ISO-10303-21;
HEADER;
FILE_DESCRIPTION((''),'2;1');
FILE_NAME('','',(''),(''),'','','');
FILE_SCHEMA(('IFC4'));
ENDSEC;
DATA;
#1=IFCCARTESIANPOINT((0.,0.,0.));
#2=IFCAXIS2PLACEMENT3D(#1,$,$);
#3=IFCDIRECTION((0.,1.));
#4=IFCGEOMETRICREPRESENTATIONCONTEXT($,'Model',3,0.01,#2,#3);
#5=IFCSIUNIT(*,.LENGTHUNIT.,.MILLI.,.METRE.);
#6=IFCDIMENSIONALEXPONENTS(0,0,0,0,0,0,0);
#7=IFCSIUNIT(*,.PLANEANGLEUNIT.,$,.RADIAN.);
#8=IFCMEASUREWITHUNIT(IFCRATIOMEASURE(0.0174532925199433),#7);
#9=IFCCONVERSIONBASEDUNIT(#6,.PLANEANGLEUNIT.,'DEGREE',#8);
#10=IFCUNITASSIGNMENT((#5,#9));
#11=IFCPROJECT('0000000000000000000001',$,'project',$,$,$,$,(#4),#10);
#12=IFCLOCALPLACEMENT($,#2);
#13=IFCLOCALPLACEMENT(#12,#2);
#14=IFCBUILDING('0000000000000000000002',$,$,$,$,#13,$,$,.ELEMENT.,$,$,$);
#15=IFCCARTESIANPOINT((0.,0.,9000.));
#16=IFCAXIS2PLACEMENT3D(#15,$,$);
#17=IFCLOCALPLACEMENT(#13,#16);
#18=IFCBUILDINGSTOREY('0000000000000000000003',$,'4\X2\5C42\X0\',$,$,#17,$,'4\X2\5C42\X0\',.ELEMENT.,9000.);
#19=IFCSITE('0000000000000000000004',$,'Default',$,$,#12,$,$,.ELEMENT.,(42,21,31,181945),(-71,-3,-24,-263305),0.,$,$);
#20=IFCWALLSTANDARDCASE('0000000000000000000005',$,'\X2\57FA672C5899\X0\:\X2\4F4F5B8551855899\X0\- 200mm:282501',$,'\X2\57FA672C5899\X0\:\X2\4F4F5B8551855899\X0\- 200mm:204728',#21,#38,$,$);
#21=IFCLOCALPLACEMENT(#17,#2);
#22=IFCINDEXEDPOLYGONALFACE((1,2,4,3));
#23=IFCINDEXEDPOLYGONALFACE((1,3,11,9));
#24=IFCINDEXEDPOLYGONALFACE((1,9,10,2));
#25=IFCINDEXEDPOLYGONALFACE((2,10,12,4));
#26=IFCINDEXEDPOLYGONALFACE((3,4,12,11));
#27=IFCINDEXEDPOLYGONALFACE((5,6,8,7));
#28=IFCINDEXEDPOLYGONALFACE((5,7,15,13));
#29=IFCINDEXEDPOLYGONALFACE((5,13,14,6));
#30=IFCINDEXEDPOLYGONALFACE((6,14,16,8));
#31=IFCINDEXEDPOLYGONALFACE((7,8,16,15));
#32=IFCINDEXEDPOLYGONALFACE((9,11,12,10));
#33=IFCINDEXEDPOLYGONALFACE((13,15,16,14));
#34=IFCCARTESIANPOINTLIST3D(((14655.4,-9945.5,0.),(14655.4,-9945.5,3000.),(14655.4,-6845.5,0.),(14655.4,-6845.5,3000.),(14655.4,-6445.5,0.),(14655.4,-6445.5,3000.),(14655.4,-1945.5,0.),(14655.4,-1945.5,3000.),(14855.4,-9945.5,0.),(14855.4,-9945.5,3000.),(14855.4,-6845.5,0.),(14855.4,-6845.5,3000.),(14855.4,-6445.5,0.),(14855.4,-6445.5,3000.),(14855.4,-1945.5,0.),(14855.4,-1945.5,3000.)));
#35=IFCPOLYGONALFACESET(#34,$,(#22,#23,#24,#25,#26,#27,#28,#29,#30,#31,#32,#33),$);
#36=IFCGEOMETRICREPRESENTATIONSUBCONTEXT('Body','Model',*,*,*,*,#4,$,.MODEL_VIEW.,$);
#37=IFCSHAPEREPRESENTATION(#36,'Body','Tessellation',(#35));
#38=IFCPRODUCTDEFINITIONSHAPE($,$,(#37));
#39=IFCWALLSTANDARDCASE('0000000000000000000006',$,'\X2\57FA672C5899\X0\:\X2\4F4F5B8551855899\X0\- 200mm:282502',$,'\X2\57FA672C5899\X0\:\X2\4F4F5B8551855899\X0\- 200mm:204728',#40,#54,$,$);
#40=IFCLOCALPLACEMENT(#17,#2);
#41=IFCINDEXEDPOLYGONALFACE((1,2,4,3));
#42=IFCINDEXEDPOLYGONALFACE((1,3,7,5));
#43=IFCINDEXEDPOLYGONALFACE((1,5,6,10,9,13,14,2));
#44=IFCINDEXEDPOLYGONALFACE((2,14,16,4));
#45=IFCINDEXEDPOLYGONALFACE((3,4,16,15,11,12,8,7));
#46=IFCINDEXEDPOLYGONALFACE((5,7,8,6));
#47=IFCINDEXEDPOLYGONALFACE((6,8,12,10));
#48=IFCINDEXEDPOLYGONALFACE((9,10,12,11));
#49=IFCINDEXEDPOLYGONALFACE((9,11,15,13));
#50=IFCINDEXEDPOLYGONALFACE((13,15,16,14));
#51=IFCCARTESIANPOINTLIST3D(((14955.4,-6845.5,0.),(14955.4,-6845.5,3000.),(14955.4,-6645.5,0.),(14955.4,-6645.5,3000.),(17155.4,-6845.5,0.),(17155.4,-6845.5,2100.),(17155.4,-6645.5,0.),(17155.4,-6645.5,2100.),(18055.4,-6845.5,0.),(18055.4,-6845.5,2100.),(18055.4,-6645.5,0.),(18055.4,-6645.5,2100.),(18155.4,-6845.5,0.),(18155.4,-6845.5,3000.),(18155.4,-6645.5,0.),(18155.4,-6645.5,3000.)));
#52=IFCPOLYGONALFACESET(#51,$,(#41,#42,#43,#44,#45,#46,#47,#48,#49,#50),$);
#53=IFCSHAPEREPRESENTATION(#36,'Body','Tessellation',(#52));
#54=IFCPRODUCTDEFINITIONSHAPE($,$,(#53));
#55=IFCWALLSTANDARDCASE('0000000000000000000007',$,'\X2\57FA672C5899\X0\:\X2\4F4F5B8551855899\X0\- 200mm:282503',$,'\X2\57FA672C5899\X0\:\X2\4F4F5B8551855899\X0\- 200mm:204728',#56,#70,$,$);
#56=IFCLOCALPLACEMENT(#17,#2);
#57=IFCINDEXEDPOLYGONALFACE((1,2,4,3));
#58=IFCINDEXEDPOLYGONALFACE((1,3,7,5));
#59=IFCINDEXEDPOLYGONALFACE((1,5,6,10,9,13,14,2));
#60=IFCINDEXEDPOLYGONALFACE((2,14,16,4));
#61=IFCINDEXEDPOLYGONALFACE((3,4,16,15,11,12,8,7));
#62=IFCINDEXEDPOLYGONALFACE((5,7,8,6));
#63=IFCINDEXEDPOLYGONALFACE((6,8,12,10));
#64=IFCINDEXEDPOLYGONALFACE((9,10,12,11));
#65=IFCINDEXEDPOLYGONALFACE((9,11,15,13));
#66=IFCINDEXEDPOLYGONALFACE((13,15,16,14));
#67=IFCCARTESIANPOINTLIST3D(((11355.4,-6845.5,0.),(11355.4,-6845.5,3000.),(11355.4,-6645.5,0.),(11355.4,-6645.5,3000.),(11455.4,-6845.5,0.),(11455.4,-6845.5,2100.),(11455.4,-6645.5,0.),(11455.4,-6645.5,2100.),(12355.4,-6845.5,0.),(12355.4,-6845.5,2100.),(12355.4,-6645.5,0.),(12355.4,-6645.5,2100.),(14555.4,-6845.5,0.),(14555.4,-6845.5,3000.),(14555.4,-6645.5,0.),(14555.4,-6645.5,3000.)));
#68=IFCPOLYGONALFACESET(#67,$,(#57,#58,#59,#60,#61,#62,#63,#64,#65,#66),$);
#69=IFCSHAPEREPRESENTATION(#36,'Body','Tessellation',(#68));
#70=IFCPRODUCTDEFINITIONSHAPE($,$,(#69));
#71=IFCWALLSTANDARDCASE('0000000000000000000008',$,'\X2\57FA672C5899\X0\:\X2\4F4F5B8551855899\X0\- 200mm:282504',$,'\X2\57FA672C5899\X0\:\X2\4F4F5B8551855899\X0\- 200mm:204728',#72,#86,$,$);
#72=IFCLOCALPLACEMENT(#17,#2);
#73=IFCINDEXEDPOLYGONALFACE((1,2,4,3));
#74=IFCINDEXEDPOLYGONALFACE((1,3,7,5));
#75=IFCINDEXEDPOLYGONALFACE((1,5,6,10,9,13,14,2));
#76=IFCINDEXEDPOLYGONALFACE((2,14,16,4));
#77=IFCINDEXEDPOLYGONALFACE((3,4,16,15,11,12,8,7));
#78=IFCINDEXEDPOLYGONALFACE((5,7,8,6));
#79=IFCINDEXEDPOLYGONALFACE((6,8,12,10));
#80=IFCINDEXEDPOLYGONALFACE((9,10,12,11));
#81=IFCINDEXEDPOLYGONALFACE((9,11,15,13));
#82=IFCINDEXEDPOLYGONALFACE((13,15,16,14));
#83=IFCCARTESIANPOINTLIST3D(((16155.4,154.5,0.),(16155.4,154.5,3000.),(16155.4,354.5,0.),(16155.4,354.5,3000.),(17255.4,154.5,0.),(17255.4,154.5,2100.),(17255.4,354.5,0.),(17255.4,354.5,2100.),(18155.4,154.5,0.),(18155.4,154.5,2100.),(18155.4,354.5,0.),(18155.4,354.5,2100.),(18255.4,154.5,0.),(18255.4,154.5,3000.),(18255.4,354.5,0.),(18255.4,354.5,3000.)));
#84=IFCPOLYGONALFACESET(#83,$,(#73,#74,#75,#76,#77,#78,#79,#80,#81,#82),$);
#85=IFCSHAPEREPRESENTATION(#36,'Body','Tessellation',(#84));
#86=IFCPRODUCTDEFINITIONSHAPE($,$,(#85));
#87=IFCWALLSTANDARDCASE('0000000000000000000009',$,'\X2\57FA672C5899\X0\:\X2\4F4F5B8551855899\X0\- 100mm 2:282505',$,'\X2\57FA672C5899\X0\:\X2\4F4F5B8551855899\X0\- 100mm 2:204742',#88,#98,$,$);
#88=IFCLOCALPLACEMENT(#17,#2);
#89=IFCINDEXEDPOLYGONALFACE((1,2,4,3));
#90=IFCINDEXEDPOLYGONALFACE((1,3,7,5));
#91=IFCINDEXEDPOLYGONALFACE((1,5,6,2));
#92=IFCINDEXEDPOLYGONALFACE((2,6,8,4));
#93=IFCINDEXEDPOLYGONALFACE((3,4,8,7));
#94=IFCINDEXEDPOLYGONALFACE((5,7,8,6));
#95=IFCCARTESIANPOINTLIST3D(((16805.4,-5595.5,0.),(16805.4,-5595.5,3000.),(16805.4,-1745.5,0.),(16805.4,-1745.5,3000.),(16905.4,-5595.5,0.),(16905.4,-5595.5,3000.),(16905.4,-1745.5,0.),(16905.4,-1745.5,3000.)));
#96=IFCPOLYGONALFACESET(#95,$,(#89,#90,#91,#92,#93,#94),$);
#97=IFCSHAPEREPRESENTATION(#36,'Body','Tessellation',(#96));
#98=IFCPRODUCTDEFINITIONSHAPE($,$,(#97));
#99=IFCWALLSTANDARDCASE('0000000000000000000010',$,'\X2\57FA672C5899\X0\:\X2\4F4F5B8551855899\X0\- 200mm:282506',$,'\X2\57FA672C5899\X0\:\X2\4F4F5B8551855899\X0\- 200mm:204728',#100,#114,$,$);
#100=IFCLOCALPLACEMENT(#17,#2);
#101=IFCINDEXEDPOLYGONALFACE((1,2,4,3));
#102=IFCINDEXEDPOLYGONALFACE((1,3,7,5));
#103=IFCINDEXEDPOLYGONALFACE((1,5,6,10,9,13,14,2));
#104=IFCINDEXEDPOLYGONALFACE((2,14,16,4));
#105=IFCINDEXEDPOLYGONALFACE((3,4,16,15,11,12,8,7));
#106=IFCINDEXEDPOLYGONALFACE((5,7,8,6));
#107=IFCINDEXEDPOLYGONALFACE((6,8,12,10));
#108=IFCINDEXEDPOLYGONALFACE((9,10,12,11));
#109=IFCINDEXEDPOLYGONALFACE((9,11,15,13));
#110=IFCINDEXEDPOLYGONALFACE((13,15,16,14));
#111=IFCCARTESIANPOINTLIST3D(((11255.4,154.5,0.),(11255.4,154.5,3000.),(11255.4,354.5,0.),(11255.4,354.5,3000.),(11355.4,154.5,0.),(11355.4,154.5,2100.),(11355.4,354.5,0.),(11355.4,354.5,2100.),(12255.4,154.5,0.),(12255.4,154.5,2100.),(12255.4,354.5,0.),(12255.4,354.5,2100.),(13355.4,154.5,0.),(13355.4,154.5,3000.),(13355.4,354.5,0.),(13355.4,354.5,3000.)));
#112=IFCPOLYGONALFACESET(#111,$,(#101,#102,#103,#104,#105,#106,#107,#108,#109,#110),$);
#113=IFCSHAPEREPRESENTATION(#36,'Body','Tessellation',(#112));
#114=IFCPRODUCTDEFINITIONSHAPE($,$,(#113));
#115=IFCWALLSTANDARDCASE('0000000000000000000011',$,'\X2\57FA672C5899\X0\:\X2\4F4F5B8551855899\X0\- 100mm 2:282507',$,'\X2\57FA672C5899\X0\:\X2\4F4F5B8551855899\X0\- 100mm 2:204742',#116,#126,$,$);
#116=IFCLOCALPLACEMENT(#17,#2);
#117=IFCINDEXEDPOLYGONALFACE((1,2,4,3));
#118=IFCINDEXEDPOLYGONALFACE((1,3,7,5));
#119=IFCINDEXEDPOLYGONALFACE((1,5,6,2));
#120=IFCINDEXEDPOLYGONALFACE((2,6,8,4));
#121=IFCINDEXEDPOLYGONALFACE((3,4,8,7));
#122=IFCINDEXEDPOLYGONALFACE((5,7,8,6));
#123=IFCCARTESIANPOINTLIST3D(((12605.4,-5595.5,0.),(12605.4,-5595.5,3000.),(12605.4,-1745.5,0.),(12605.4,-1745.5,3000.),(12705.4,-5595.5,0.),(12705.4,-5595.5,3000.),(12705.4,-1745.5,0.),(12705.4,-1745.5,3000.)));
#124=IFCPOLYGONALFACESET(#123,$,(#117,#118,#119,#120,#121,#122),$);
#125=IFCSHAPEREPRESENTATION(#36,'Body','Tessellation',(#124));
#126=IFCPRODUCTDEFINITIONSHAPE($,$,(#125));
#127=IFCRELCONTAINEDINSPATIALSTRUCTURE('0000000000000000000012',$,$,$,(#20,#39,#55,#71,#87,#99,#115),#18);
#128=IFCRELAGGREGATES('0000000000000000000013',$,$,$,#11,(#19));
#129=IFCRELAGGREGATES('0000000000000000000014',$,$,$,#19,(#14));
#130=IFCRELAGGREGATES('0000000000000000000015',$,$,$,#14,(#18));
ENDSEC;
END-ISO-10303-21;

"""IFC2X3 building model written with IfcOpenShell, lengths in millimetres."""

from ifc_helpers import new_model, entity, si_unit, converted_unit, direction, frame, frame_2d, origin, place, context, subcontext, project, spatial, polyline, rectangle, extrude, clip, bounded_halfspace, element, save


model = new_model("IFC2X3")

# Units and contexts
model_context = context("Model", 3, precision=0.01, world=origin(), true_north=direction((0.0, 1.0)))
body_context = subcontext(model_context, "Body", "Model", "MODEL_VIEW")
ifc_project = project(units=[si_unit("LENGTHUNIT", "METRE", prefix="MILLI"), converted_unit("PLANEANGLEUNIT", "DEGREE", entity("IfcRatioMeasure", 0.0174532925199433), si_unit("PLANEANGLEUNIT", "RADIAN"), dimensions=[0, 0, 0, 0, 0, 0, 0])], contexts=[model_context])

# Site, building, storey
site_placement = place(None, origin())
site = spatial("IfcSite", under=ifc_project, at=site_placement, Name="Default", CompositionType="ELEMENT", RefLatitude=(42, 21, 31, 181945), RefLongitude=(-71, -3, -24, -263305), RefElevation=0.0)
building_placement = place(site_placement, origin())
building = spatial("IfcBuilding", under=site, at=building_placement, CompositionType="ELEMENT")
storey_placement = place(building_placement, frame((0.0, 0.0, 9000.0)))
storey = spatial("IfcBuildingStorey", under=building, at=storey_placement, Name="4层", LongName="4层", CompositionType="ELEMENT", Elevation=9000.0)

# Walls, openings
wall_1_placement = place(storey_placement, frame((14755.4, -1945.5, 0.0), z_axis=(0.0, 0.0, 1.0), x_axis=(0.0, -1.0, 0.0)))
wall_1 = element("IfcWallStandardCase", 1, at=wall_1_placement, inside=storey, Name="基本墙:住宅内墙- 200mm:282501", ObjectType="基本墙:住宅内墙- 200mm:204728", context=body_context, shape_type="Clipping", body=[
    clip(extrude(rectangle(XDim=8000.0, YDim=200.0, at=frame_2d((4000.0, 0.0), x_axis=(-1.0, 0.0))), origin(), (0.0, 0.0, 1.0), 3000.0), bounded_halfspace(frame((8000.0, -100.0, 3000.0), z_axis=(1.0, 0.0, 0.0), x_axis=(0.0, 0.0, -1.0)), False, frame((8000.0, -100.0, 3000.0), z_axis=(1.0, 0.0, 0.0), x_axis=(0.0, 0.0, -1.0)), polyline([(0.0, 0.0), (3000.0, 0.0), (3000.0, 200.0), (0.0, 200.0), (0.0, 0.0)]))),
])
opening_1_placement = place(storey_placement, frame((14755.4, -1945.5, 0.0), z_axis=(0.0, 0.0, 1.0), x_axis=(0.0, -1.0, 0.0)))
element("IfcOpeningElement", 2, at=opening_1_placement, cuts=wall_1, ObjectType="Opening", context=body_context, shape_type="SweptSolid", body=[
    extrude(rectangle(XDim=3000.0, YDim=200.0, at=frame_2d((0.0, 0.0), x_axis=(1.0, 0.0))), frame((4900.0, 0.0, 1500.0), z_axis=(-1.0, 0.0, 0.0), x_axis=(0.0, 0.0, 1.0)), (0.0, 0.0, 1.0), 400.0),
])
wall_2_placement = place(storey_placement, frame((18155.4, -6745.5, 0.0), z_axis=(0.0, 0.0, 1.0), x_axis=(-1.0, 0.0, 0.0)))
wall_2 = element("IfcWallStandardCase", 3, at=wall_2_placement, inside=storey, Name="基本墙:住宅内墙- 200mm:282502", ObjectType="基本墙:住宅内墙- 200mm:204728", context=body_context, shape_type="Clipping", body=[
    clip(clip(extrude(rectangle(XDim=3200.0, YDim=200.0, at=frame_2d((1600.0, 0.0), x_axis=(-1.0, 0.0))), origin(), (0.0, 0.0, 1.0), 3000.0), bounded_halfspace(frame((0.0, -100.0, 0.0), z_axis=(-1.0, 0.0, 0.0), x_axis=(0.0, 0.0, -1.0)), False, frame((0.0, -100.0, 0.0), z_axis=(-1.0, 0.0, 0.0), x_axis=(0.0, 0.0, -1.0)), polyline([(0.0, 0.0), (-3000.0, 0.0), (-3000.0, -200.0), (0.0, -200.0), (0.0, 0.0)]))), bounded_halfspace(frame((3200.0, -100.0, 3000.0), z_axis=(1.0, 0.0, 0.0), x_axis=(0.0, 0.0, -1.0)), False, frame((3200.0, -100.0, 3000.0), z_axis=(1.0, 0.0, 0.0), x_axis=(0.0, 0.0, -1.0)), polyline([(0.0, 0.0), (3000.0, 0.0), (3000.0, 200.0), (0.0, 200.0), (0.0, 0.0)]))),
])
opening_2_placement = place(wall_2_placement, frame((100.0, -100.0, 0.0)))
element("IfcOpeningElement", 4, at=opening_2_placement, cuts=wall_2, ObjectType="Opening", context=body_context, shape_type="SweptSolid", body=[
    extrude(rectangle(XDim=2100.0, YDim=900.0, at=frame_2d((1050.0, 450.0), x_axis=(1.0, 0.0))), frame((0.0, 0.0, 0.0), z_axis=(0.0, 1.0, 0.0), x_axis=(0.0, 0.0, 1.0)), (0.0, 0.0, 1.0), 200.0),
])
wall_3_placement = place(storey_placement, frame((11355.4, -6745.5, 0.0)))
wall_3 = element("IfcWallStandardCase", 5, at=wall_3_placement, inside=storey, Name="基本墙:住宅内墙- 200mm:282503", ObjectType="基本墙:住宅内墙- 200mm:204728", context=body_context, shape_type="Clipping", body=[
    clip(clip(extrude(rectangle(XDim=3200.0, YDim=200.0, at=frame_2d((1600.0, 0.0), x_axis=(-1.0, 0.0))), origin(), (0.0, 0.0, 1.0), 3000.0), bounded_halfspace(frame((0.0, -100.0, 0.0), z_axis=(1.0, 0.0, 0.0), x_axis=(0.0, 0.0, -1.0)), True, frame((0.0, -100.0, 0.0), z_axis=(1.0, 0.0, 0.0), x_axis=(0.0, 0.0, -1.0)), polyline([(0.0, 0.0), (0.0, 200.0), (-3000.0, 200.0), (-3000.0, 0.0), (0.0, 0.0)]))), bounded_halfspace(frame((3200.0, -100.0, 3000.0), z_axis=(1.0, 0.0, 0.0), x_axis=(0.0, 0.0, -1.0)), False, frame((3200.0, -100.0, 3000.0), z_axis=(1.0, 0.0, 0.0), x_axis=(0.0, 0.0, -1.0)), polyline([(0.0, 0.0), (3000.0, 0.0), (3000.0, 200.0), (0.0, 200.0), (0.0, 0.0)]))),
])
opening_3_placement = place(wall_3_placement, frame((1000.0, 100.0, 0.0)))
element("IfcOpeningElement", 6, at=opening_3_placement, cuts=wall_3, ObjectType="Opening", context=body_context, shape_type="SweptSolid", body=[
    extrude(rectangle(XDim=2100.0, YDim=900.0, at=frame_2d((1050.0, 450.0), x_axis=(1.0, 0.0))), frame((0.0, 0.0, 0.0), z_axis=(0.0, -1.0, 0.0), x_axis=(0.0, 0.0, 1.0)), (0.0, 0.0, 1.0), 200.0),
])
wall_4_placement = place(storey_placement, frame((18255.4, 254.5, 0.0), z_axis=(0.0, 0.0, 1.0), x_axis=(-1.0, 0.0, 0.0)))
wall_4 = element("IfcWallStandardCase", 7, at=wall_4_placement, inside=storey, Name="基本墙:住宅内墙- 200mm:282504", ObjectType="基本墙:住宅内墙- 200mm:204728", context=body_context, shape_type="SweptSolid", body=[
    extrude(rectangle(XDim=2100.0, YDim=200.0, at=frame_2d((1050.0, 0.0), x_axis=(-1.0, 0.0))), origin(), (0.0, 0.0, 1.0), 3000.0),
])
opening_4_placement = place(wall_4_placement, frame((1000.0, 100.0, 0.0)))
element("IfcOpeningElement", 8, at=opening_4_placement, cuts=wall_4, ObjectType="Opening", context=body_context, shape_type="SweptSolid", body=[
    extrude(rectangle(XDim=2100.0, YDim=900.0, at=frame_2d((1050.0, 450.0), x_axis=(1.0, 0.0))), frame((0.0, 0.0, 0.0), z_axis=(0.0, -1.0, 0.0), x_axis=(0.0, 0.0, 1.0)), (0.0, 0.0, 1.0), 200.0),
])

# Wall
wall_5_placement = place(storey_placement, frame((16855.4, -1745.5, 0.0), z_axis=(0.0, 0.0, 1.0), x_axis=(0.0, -1.0, 0.0)))
element("IfcWallStandardCase", 9, at=wall_5_placement, inside=storey, Name="基本墙:住宅内墙- 100mm 2:282505", ObjectType="基本墙:住宅内墙- 100mm 2:204742", context=body_context, shape_type="SweptSolid", body=[
    extrude(rectangle(XDim=3850.0, YDim=100.0, at=frame_2d((1925.0, 0.0), x_axis=(-1.0, 0.0))), origin(), (0.0, 0.0, 1.0), 3000.0),
])

# Wall, opening
wall_6_placement = place(storey_placement, frame((11255.4, 254.5, 0.0)))
wall_6 = element("IfcWallStandardCase", 10, at=wall_6_placement, inside=storey, Name="基本墙:住宅内墙- 200mm:282506", ObjectType="基本墙:住宅内墙- 200mm:204728", context=body_context, shape_type="SweptSolid", body=[
    extrude(rectangle(XDim=2100.0, YDim=200.0, at=frame_2d((1050.0, 0.0), x_axis=(-1.0, 0.0))), origin(), (0.0, 0.0, 1.0), 3000.0),
])
opening_5_placement = place(wall_6_placement, frame((100.0, -100.0, 0.0)))
element("IfcOpeningElement", 11, at=opening_5_placement, cuts=wall_6, ObjectType="Opening", context=body_context, shape_type="SweptSolid", body=[
    extrude(rectangle(XDim=2100.0, YDim=900.0, at=frame_2d((1050.0, 450.0), x_axis=(1.0, 0.0))), frame((0.0, 0.0, 0.0), z_axis=(0.0, 1.0, 0.0), x_axis=(0.0, 0.0, 1.0)), (0.0, 0.0, 1.0), 200.0),
])

# Wall
wall_7_placement = place(storey_placement, frame((12655.4, -1745.5, 0.0), z_axis=(0.0, 0.0, 1.0), x_axis=(0.0, -1.0, 0.0)))
element("IfcWallStandardCase", 12, at=wall_7_placement, inside=storey, Name="基本墙:住宅内墙- 100mm 2:282507", ObjectType="基本墙:住宅内墙- 100mm 2:204742", context=body_context, shape_type="SweptSolid", body=[
    extrude(rectangle(XDim=3850.0, YDim=100.0, at=frame_2d((1925.0, 0.0), x_axis=(-1.0, 0.0))), origin(), (0.0, 0.0, 1.0), 3000.0),
])

save(model, "model.ifc")
